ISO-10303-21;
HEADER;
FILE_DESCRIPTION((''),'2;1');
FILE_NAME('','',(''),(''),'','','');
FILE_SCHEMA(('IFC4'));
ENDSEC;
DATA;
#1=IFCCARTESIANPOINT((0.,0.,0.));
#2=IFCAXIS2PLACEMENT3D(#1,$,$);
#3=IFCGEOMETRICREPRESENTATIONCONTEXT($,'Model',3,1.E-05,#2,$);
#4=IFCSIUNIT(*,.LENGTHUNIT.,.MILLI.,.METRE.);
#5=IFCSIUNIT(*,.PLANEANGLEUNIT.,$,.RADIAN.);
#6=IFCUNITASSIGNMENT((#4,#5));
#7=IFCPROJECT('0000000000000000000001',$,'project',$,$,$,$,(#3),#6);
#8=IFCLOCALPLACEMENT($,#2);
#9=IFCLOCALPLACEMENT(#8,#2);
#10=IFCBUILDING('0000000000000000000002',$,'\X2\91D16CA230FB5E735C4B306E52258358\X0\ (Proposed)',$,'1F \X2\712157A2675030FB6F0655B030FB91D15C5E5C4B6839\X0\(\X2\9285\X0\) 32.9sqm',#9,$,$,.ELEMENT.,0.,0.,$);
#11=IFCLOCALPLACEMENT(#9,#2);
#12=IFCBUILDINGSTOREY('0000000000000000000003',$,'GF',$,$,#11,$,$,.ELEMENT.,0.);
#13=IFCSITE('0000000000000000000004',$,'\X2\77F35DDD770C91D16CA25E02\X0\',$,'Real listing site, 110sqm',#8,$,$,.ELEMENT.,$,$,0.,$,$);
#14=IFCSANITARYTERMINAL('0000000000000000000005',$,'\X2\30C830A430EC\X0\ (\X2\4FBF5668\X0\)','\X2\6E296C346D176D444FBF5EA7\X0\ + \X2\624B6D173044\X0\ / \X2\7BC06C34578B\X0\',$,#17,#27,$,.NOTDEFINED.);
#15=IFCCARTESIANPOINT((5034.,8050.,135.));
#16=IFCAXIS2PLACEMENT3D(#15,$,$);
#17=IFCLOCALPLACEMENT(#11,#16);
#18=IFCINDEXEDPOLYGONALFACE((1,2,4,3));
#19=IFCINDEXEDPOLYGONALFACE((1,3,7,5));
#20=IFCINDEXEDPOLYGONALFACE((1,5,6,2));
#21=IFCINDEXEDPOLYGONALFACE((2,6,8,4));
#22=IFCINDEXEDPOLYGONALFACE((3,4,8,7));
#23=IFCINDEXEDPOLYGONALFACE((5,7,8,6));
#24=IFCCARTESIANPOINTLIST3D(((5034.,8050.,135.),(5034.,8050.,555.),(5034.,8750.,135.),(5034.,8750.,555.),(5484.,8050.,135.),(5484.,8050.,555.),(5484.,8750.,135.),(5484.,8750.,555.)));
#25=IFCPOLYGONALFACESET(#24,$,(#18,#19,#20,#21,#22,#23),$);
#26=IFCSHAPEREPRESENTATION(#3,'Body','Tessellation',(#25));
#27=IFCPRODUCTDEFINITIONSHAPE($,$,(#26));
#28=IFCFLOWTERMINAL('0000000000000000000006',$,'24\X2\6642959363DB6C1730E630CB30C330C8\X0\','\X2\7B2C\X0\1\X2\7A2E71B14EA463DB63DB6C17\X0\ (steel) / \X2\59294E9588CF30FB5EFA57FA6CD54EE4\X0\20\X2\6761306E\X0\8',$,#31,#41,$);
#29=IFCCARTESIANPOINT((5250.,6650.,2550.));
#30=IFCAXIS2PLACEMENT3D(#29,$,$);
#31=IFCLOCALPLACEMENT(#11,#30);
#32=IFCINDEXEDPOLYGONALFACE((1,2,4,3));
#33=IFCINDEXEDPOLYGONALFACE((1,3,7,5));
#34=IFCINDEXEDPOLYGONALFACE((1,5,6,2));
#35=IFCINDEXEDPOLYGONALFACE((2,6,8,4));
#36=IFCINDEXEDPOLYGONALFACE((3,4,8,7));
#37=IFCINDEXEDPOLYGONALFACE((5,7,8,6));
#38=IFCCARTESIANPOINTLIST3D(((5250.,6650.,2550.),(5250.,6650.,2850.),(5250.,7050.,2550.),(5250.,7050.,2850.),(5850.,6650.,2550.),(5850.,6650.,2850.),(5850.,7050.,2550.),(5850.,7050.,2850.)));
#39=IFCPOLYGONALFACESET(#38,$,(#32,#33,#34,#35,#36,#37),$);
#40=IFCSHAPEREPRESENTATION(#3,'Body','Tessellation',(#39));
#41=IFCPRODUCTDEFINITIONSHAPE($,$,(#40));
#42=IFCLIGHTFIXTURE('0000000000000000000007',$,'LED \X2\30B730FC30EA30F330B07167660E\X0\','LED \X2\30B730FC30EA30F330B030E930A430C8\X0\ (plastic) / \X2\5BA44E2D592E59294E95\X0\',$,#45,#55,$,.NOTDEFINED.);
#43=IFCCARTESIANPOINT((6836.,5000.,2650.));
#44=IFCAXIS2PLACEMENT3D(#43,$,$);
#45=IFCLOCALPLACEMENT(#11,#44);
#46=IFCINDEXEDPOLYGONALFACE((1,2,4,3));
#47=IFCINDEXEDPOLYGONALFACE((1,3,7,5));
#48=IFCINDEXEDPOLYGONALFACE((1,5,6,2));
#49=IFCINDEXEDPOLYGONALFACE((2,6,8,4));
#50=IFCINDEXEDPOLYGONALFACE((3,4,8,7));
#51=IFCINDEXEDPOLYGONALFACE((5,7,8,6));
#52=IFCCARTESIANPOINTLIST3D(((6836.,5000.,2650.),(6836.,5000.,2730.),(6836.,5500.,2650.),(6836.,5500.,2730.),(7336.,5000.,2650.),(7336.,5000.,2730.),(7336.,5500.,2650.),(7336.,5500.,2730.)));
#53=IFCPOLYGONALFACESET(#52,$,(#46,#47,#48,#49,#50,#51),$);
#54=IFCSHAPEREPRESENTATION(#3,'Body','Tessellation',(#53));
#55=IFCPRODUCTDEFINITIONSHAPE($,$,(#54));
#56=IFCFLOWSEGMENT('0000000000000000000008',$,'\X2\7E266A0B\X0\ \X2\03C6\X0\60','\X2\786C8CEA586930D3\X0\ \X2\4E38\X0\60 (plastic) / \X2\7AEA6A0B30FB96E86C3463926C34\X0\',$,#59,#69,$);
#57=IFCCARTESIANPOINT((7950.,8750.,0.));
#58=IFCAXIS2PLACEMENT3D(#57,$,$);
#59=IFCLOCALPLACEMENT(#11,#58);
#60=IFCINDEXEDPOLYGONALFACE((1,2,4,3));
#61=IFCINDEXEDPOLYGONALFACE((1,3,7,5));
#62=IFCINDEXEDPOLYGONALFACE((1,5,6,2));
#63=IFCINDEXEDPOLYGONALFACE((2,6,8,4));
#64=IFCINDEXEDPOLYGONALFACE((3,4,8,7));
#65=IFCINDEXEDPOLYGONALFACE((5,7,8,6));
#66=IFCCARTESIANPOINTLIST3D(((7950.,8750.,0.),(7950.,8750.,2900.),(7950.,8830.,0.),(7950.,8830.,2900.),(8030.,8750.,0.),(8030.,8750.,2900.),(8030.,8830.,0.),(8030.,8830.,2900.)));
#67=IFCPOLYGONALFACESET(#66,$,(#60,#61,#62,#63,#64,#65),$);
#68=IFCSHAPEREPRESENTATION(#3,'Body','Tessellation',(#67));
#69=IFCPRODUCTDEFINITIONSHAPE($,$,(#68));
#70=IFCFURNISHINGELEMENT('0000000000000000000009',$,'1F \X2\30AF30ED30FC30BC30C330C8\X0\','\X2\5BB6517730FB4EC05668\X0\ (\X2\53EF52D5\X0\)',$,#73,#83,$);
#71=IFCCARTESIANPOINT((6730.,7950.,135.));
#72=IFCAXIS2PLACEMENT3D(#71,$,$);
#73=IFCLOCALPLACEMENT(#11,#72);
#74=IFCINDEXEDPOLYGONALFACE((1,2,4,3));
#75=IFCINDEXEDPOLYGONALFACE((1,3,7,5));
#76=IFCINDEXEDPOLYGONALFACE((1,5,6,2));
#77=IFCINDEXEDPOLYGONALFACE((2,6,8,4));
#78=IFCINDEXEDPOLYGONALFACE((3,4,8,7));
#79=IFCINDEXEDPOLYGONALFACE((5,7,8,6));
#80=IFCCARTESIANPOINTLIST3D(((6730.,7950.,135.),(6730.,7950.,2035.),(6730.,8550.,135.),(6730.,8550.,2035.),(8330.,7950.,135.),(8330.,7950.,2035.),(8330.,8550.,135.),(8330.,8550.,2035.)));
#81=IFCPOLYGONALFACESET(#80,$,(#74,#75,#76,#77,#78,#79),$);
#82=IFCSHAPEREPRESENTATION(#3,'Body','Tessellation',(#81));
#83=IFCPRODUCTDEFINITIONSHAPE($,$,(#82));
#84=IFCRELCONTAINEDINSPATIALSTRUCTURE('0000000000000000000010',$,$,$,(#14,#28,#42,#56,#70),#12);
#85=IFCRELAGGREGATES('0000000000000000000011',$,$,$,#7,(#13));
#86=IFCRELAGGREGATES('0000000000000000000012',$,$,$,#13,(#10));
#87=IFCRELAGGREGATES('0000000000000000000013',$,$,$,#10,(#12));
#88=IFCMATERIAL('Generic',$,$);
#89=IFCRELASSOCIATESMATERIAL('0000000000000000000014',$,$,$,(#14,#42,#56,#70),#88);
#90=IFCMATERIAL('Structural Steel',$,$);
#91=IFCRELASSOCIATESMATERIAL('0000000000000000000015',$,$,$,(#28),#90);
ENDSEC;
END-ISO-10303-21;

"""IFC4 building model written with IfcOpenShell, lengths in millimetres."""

from ifc_helpers import new_model, si_unit, frame, frame_2d, origin, place, context, project, spatial, rectangle, extrude, material, element, save


model = new_model("IFC4")

# Units and contexts
model_context = context("Model", 3, precision=1e-05, world=origin())
ifc_project = project(units=[si_unit("LENGTHUNIT", "METRE", prefix="MILLI"), si_unit("PLANEANGLEUNIT", "RADIAN")], contexts=[model_context])

# Site, building, storey
site_placement = place(None, origin())
site = spatial("IfcSite", under=ifc_project, at=site_placement, Name="石川県金沢市", ObjectType="Real listing site, 110sqm", CompositionType="ELEMENT", RefElevation=0.0)
building_placement = place(site_placement, origin())
building = spatial("IfcBuilding", under=site, at=building_placement, Name="金沢・平屋の別荘 (Proposed)", ObjectType="1F 無垢材・漆喰・金属屋根(銅) 32.9sqm", CompositionType="ELEMENT", ElevationOfRefHeight=0.0, ElevationOfTerrain=0.0)
storey_placement = place(building_placement, origin())
storey = spatial("IfcBuildingStorey", under=building, at=storey_placement, Name="GF", CompositionType="ELEMENT", Elevation=0.0)

# Shared definitions
ifc_material_1 = material(Name="Generic")

# Sanitary terminal
sanitary_terminal_placement = place(storey_placement, frame((5034.0, 8050.0, 135.0)))
element("IfcSanitaryTerminal", 1, at=sanitary_terminal_placement, inside=storey, material=ifc_material_1, Name="トイレ (便器)", Description="温水洗浄便座 + 手洗い / 節水型", PredefinedType="NOTDEFINED", context=model_context, shape_type="SweptSolid", body=[
    extrude(rectangle(XDim=450.0, YDim=700.0, at=frame_2d((225.0, 350.0))), frame((5034.0, 8050.0, 135.0)), (0.0, 0.0, 1.0), 420.0),
])

# Flow terminal
ifc_material_2 = material(Name="Structural Steel")
flow_terminal_placement = place(storey_placement, frame((5250.0, 6650.0, 2550.0)))
element("IfcFlowTerminal", 2, at=flow_terminal_placement, inside=storey, material=ifc_material_2, Name="24時間換気ユニット", Description="第1種熱交換換気 (steel) / 天井裏・建基法令20条の8", context=model_context, shape_type="SweptSolid", body=[
    extrude(rectangle(XDim=600.0, YDim=400.0, at=frame_2d((300.0, 200.0))), frame((5250.0, 6650.0, 2550.0)), (0.0, 0.0, 1.0), 300.0),
])

# Light fixture
light_fixture_placement = place(storey_placement, frame((6836.0, 5000.0, 2650.0)))
element("IfcLightFixture", 3, at=light_fixture_placement, inside=storey, material=ifc_material_1, Name="LED シーリング照明", Description="LED シーリングライト (plastic) / 室中央天井", PredefinedType="NOTDEFINED", context=model_context, shape_type="SweptSolid", body=[
    extrude(rectangle(XDim=500.0, YDim=500.0, at=frame_2d((250.0, 250.0))), frame((6836.0, 5000.0, 2650.0)), (0.0, 0.0, 1.0), 80.0),
])

# Flow segment
flow_segment_placement = place(storey_placement, frame((7950.0, 8750.0, 0.0)))
element("IfcFlowSegment", 4, at=flow_segment_placement, inside=storey, material=ifc_material_1, Name="縦樋 φ60", Description="硬質塩ビ 丸60 (plastic) / 竪樋・雨水排水", context=model_context, shape_type="SweptSolid", body=[
    extrude(rectangle(XDim=80.0, YDim=80.0, at=frame_2d((40.0, 40.0))), frame((7950.0, 8750.0, 0.0)), (0.0, 0.0, 1.0), 2900.0),
])

# Furnishing element
furnishing_placement = place(storey_placement, frame((6730.0, 7950.0, 135.0)))
element("IfcFurnishingElement", 5, at=furnishing_placement, inside=storey, material=ifc_material_1, Name="1F クローゼット", Description="家具・什器 (可動)", context=model_context, shape_type="SweptSolid", body=[
    extrude(rectangle(XDim=1600.0, YDim=600.0, at=frame_2d((800.0, 300.0))), frame((6730.0, 7950.0, 135.0)), (0.0, 0.0, 1.0), 1900.0),
])

save(model, "model.ifc")
